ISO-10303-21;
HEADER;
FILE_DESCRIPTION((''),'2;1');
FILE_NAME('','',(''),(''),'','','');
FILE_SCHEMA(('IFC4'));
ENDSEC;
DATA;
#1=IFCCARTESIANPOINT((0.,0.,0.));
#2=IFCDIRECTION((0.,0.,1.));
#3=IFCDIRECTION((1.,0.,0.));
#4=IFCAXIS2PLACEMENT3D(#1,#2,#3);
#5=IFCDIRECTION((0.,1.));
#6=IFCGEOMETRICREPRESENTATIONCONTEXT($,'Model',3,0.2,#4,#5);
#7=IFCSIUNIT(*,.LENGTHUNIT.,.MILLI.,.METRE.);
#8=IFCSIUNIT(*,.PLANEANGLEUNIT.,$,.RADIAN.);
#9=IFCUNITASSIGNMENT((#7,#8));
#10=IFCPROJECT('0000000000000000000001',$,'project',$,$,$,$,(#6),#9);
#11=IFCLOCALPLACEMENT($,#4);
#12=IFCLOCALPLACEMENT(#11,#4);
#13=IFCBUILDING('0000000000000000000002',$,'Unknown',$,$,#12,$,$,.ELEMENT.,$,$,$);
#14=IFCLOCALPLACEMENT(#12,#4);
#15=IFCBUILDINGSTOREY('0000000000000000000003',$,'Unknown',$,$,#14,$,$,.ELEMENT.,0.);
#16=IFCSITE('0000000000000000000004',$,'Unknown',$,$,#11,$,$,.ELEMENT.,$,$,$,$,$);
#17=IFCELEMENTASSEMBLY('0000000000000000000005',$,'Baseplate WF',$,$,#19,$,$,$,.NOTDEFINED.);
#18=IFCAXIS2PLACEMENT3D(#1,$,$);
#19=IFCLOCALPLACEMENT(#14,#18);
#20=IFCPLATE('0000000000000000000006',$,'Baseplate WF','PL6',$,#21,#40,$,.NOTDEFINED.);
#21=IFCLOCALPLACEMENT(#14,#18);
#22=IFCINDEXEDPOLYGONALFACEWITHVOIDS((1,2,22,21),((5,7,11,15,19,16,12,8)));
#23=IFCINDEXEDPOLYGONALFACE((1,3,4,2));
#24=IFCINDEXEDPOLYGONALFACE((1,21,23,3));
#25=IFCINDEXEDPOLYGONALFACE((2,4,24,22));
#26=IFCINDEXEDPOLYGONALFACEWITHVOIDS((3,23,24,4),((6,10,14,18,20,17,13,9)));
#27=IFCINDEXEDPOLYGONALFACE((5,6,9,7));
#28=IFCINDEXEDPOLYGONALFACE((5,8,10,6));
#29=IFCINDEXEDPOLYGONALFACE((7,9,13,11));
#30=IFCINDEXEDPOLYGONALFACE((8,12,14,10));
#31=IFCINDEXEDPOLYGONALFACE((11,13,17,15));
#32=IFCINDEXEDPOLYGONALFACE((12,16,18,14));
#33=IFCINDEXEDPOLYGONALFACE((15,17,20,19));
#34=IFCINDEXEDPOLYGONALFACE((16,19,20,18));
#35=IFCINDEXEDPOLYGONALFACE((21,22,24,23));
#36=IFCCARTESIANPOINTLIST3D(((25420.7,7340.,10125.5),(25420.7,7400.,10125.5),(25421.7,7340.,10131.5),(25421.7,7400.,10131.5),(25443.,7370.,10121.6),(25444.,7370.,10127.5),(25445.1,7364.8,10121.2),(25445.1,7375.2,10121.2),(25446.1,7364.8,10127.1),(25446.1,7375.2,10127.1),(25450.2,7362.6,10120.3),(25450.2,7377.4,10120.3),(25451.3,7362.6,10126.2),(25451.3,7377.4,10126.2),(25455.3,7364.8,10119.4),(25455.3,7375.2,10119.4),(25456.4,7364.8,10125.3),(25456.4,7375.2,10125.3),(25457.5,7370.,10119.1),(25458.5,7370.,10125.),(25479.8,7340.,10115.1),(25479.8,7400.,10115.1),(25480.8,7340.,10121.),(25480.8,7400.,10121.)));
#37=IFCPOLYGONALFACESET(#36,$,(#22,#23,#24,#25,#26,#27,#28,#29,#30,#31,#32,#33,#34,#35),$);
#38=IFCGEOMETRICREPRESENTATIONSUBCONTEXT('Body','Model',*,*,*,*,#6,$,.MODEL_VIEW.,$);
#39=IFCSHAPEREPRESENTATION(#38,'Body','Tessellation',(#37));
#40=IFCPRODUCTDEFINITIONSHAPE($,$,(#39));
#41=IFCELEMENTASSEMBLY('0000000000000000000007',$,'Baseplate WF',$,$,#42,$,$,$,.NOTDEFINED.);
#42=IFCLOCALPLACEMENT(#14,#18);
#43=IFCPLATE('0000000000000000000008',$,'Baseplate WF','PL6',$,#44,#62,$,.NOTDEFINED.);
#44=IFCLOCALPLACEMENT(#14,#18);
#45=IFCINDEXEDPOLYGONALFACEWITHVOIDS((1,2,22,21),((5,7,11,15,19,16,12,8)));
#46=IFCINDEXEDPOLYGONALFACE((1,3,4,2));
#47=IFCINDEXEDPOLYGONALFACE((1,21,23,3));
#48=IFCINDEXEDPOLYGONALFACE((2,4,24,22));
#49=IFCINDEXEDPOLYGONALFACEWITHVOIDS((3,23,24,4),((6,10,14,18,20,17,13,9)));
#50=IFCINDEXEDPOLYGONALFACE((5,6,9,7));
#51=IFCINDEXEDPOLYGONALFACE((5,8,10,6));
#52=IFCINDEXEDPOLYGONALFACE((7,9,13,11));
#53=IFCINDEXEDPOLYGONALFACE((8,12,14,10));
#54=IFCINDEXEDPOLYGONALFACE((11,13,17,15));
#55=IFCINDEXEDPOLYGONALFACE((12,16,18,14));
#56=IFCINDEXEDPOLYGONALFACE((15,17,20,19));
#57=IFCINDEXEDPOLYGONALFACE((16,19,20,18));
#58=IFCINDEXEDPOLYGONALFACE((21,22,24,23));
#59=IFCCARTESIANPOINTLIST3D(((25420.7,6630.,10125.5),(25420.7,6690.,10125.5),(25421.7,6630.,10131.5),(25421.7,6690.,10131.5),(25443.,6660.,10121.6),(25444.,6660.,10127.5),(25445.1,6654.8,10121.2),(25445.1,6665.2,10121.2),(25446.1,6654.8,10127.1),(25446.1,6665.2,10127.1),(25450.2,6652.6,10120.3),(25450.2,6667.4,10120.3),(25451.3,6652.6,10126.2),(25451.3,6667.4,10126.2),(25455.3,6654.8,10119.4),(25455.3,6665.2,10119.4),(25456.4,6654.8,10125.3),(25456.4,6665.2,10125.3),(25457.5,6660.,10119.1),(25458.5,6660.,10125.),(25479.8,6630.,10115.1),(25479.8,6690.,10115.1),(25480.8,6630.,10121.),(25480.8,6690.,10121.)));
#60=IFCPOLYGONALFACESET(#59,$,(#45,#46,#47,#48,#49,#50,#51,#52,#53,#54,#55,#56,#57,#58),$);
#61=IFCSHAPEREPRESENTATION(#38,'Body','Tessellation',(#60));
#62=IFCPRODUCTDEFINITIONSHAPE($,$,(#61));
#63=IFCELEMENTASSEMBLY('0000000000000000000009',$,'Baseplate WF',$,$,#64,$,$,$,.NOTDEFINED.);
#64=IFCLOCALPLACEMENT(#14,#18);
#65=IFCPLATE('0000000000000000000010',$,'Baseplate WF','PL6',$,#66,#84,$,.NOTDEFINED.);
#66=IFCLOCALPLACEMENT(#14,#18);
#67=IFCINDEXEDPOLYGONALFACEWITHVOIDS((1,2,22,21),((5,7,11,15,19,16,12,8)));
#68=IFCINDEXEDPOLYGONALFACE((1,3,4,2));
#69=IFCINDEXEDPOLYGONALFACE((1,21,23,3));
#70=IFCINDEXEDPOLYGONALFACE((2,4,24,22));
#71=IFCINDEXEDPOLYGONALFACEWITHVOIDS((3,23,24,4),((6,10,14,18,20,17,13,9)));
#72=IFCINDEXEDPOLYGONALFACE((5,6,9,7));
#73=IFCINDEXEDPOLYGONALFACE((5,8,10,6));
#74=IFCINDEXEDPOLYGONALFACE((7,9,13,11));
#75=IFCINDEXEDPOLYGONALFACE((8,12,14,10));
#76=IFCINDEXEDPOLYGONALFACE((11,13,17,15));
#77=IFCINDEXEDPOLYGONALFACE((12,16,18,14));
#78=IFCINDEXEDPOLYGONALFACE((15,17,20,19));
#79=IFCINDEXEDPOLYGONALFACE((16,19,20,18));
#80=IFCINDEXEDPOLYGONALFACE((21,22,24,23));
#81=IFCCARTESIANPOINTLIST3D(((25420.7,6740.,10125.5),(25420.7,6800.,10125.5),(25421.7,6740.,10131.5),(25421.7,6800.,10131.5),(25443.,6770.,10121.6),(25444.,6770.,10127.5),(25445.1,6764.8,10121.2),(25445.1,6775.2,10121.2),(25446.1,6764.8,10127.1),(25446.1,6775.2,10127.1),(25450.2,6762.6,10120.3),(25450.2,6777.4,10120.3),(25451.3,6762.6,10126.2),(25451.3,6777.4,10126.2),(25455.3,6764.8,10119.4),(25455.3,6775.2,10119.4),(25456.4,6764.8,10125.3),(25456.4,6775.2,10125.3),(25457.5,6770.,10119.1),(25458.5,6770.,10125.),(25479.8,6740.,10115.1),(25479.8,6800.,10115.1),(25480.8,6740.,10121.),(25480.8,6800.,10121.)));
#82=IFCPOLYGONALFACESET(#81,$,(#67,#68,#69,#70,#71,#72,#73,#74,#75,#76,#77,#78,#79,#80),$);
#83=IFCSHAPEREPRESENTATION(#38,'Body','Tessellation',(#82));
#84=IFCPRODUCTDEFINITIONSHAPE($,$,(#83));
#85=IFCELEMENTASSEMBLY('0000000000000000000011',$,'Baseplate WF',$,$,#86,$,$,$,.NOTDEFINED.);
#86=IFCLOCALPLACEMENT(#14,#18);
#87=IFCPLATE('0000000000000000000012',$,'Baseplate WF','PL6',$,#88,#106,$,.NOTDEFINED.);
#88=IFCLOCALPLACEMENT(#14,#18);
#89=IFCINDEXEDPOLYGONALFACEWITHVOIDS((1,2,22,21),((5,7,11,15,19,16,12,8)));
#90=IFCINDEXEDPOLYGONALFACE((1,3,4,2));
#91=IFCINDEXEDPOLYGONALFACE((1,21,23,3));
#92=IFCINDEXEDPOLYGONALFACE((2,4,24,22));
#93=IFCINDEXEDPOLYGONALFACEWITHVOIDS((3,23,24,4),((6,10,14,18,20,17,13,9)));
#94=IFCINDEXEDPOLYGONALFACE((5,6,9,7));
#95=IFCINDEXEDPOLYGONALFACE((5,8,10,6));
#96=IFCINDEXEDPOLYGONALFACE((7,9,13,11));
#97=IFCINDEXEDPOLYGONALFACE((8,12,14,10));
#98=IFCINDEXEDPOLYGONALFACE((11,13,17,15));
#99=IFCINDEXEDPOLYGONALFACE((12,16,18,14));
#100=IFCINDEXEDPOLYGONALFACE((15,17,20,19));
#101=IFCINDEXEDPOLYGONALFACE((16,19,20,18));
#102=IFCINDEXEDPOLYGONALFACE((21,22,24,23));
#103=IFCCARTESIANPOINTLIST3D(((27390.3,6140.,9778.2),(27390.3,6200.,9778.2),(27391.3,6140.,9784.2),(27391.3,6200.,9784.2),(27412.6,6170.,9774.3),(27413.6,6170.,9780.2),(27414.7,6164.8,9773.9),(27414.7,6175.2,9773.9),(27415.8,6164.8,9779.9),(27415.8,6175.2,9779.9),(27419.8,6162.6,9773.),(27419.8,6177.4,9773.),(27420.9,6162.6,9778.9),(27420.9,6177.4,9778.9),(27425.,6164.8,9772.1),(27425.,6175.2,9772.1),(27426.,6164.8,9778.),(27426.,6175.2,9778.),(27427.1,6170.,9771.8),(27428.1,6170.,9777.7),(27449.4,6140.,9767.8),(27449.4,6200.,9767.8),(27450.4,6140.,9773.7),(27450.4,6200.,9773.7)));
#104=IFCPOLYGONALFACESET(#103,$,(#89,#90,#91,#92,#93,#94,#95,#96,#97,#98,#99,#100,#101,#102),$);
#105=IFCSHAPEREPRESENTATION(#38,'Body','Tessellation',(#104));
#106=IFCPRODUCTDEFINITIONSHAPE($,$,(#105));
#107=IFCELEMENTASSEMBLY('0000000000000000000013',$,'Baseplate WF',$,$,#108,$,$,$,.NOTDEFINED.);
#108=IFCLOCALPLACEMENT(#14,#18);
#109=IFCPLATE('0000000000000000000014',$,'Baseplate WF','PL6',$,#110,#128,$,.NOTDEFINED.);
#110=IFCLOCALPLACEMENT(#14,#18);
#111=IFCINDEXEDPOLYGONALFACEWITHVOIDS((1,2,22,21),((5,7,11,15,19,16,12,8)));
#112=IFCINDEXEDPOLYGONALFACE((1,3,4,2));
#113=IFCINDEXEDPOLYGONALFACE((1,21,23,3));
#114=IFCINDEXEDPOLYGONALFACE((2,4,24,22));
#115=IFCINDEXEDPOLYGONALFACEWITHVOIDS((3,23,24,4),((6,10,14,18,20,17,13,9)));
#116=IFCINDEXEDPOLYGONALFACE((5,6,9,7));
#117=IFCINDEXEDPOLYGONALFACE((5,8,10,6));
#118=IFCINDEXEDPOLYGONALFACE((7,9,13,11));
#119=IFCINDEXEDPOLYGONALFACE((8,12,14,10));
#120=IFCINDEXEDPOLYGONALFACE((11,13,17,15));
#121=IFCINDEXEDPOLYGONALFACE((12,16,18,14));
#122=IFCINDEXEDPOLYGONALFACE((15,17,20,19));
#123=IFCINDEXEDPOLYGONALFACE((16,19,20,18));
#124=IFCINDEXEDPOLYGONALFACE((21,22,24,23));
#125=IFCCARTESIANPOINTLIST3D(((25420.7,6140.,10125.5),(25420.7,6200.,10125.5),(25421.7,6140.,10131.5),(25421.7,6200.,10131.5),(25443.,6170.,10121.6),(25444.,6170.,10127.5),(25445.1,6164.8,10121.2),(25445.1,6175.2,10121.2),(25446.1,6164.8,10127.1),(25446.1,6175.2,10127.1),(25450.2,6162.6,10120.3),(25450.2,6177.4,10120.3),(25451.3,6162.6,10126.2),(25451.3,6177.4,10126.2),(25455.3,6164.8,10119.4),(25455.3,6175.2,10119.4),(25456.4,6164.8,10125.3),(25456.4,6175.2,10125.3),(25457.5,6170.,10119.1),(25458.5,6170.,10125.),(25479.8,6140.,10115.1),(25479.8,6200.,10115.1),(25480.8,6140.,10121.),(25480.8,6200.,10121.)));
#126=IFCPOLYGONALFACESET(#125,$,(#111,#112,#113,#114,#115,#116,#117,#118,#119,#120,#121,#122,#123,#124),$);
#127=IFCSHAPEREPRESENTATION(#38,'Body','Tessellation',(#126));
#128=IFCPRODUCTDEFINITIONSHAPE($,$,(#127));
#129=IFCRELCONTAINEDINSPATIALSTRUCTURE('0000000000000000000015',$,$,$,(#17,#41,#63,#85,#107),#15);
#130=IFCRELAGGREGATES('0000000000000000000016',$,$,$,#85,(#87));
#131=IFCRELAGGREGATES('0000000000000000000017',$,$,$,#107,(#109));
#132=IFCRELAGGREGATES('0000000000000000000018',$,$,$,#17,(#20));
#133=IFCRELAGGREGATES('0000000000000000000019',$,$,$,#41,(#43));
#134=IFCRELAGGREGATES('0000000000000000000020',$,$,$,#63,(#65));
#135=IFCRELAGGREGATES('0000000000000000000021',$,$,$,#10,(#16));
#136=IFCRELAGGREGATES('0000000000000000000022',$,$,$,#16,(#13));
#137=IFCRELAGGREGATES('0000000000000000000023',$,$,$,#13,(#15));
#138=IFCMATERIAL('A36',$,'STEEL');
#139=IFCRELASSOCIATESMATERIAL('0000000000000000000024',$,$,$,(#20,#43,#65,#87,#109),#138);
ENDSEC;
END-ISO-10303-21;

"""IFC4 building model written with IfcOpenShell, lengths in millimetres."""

from ifc_helpers import new_model, si_unit, direction, frame, origin_with_axes, place, context, subcontext, project, spatial, line, indexed_curve, outline, extrude, material, element, aggregate, save


model = new_model("IFC4")

# Units and contexts
model_context = context("Model", 3, precision=0.2, world=origin_with_axes(), true_north=direction((0.0, 1.0)))
body_context = subcontext(model_context, "Body", "Model", "MODEL_VIEW")
ifc_project = project(units=[si_unit("LENGTHUNIT", "METRE", prefix="MILLI"), si_unit("PLANEANGLEUNIT", "RADIAN")], contexts=[model_context])

# Site, building, storey
site_placement = place(None, origin_with_axes())
site = spatial("IfcSite", under=ifc_project, at=site_placement, Name="Unknown", CompositionType="ELEMENT")
building_placement = place(site_placement, origin_with_axes())
building = spatial("IfcBuilding", under=site, at=building_placement, Name="Unknown", CompositionType="ELEMENT")
storey_placement = place(building_placement, origin_with_axes())
storey = spatial("IfcBuildingStorey", under=building, at=storey_placement, Name="Unknown", CompositionType="ELEMENT", Elevation=0.0)

# Shared definitions
ifc_material_1 = material(Name="A36", Category="STEEL")

# Element assemblies, plates, voiding features
assembly_1_placement = place(storey_placement, frame((25480.3, 7400.0, 10118.1), z_axis=(-0.173648, 0.0, -0.984808), x_axis=(0.0, -1.0, 0.0)))
assembly_1 = element("IfcElementAssembly", 1, at=assembly_1_placement, inside=storey, Name="Baseplate WF", PredefinedType="NOTDEFINED")
plate_1_placement = place(assembly_1_placement, origin_with_axes())
plate_1 = element("IfcPlate", 2, at=plate_1_placement, material=ifc_material_1, Name="Baseplate WF", Description="PL6", PredefinedType="NOTDEFINED", context=body_context, shape_type="SolidModel", body=[
    extrude(outline(indexed_curve([(0.0, 0.0), (60.0, 0.0), (60.0, 60.0), (0.0, 60.0)], segments=[line(1, 2, 3, 4, 1)])), frame((0.0, 0.0, 3.0), z_axis=(0.0, 0.0, 1.0), x_axis=(1.0, 0.0, 0.0)), (0.0, 0.0, -1.0), 6.0),
])
voiding_feature_1_placement = place(plate_1_placement, frame((140.0, 30.0, -3.5), z_axis=(-1.0, 0.0, 0.0), x_axis=(0.0, 0.0, 1.0)))
element("IfcVoidingFeature", 3, at=voiding_feature_1_placement, cuts=plate_1, Name="BEAM", PredefinedType="HOLE", context=body_context, shape_type="SolidModel", body=[
    extrude(outline(indexed_curve([(7.4, 0.0), (5.2, 5.2), (0.0, 7.4), (-5.2, 5.2), (-7.4, 0.0), (-5.2, -5.2), (0.0, -7.4), (5.2, -5.2)], segments=[line(1, 2, 3, 4, 5, 6, 7, 8, 1)])), frame((0.0, 0.0, 0.0), z_axis=(-1.0, 0.0, 0.0), x_axis=(0.0, 0.0, 1.0)), (0.0, 0.0, -1.0), 7.0),
])
voiding_feature_2_placement = place(plate_1_placement, frame((30.0, 30.0, -3.5), z_axis=(-1.0, 0.0, 0.0), x_axis=(0.0, 0.0, 1.0)))
element("IfcVoidingFeature", 4, at=voiding_feature_2_placement, cuts=plate_1, Name="BEAM", PredefinedType="HOLE", context=body_context, shape_type="SolidModel", body=[
    extrude(outline(indexed_curve([(7.4, 0.0), (5.2, 5.2), (0.0, 7.4), (-5.2, 5.2), (-7.4, 0.0), (-5.2, -5.2), (0.0, -7.4), (5.2, -5.2)], segments=[line(1, 2, 3, 4, 5, 6, 7, 8, 1)])), frame((0.0, 0.0, 0.0), z_axis=(-1.0, 0.0, 0.0), x_axis=(0.0, 0.0, 1.0)), (0.0, 0.0, -1.0), 7.0),
])
assembly_2_placement = place(storey_placement, frame((25480.3, 6690.0, 10118.1), z_axis=(-0.173648, 0.0, -0.984808), x_axis=(0.0, -1.0, 0.0)))
assembly_2 = element("IfcElementAssembly", 5, at=assembly_2_placement, inside=storey, Name="Baseplate WF", PredefinedType="NOTDEFINED")
plate_2_placement = place(assembly_2_placement, origin_with_axes())
plate_2 = element("IfcPlate", 6, at=plate_2_placement, material=ifc_material_1, Name="Baseplate WF", Description="PL6", PredefinedType="NOTDEFINED", context=body_context, shape_type="SolidModel", body=[
    extrude(outline(indexed_curve([(0.0, 0.0), (60.0, 0.0), (60.0, 60.0), (0.0, 60.0)], segments=[line(1, 2, 3, 4, 1)])), frame((0.0, 0.0, 3.0), z_axis=(0.0, 0.0, 1.0), x_axis=(1.0, 0.0, 0.0)), (0.0, 0.0, -1.0), 6.0),
])
voiding_feature_3_placement = place(plate_2_placement, frame((30.0, 30.0, -3.5), z_axis=(-1.0, 0.0, 0.0), x_axis=(0.0, 0.0, 1.0)))
element("IfcVoidingFeature", 7, at=voiding_feature_3_placement, cuts=plate_2, Name="BEAM", PredefinedType="HOLE", context=body_context, shape_type="SolidModel", body=[
    extrude(outline(indexed_curve([(7.4, 0.0), (5.2, 5.2), (0.0, 7.4), (-5.2, 5.2), (-7.4, 0.0), (-5.2, -5.2), (0.0, -7.4), (5.2, -5.2)], segments=[line(1, 2, 3, 4, 5, 6, 7, 8, 1)])), frame((0.0, 0.0, 0.0), z_axis=(-1.0, 0.0, 0.0), x_axis=(0.0, 0.0, 1.0)), (0.0, 0.0, -1.0), 7.0),
])
voiding_feature_4_placement = place(plate_2_placement, frame((-80.0, 30.0, -3.5), z_axis=(-1.0, 0.0, 0.0), x_axis=(0.0, 0.0, 1.0)))
element("IfcVoidingFeature", 8, at=voiding_feature_4_placement, cuts=plate_2, Name="BEAM", PredefinedType="HOLE", context=body_context, shape_type="SolidModel", body=[
    extrude(outline(indexed_curve([(7.4, 0.0), (5.2, 5.2), (0.0, 7.4), (-5.2, 5.2), (-7.4, 0.0), (-5.2, -5.2), (0.0, -7.4), (5.2, -5.2)], segments=[line(1, 2, 3, 4, 5, 6, 7, 8, 1)])), frame((0.0, 0.0, 0.0), z_axis=(-1.0, 0.0, 0.0), x_axis=(0.0, 0.0, 1.0)), (0.0, 0.0, -1.0), 7.0),
])
assembly_3_placement = place(storey_placement, frame((25480.3, 6800.0, 10118.1), z_axis=(-0.173648, 0.0, -0.984808), x_axis=(0.0, -1.0, 0.0)))
assembly_3 = element("IfcElementAssembly", 9, at=assembly_3_placement, inside=storey, Name="Baseplate WF", PredefinedType="NOTDEFINED")
plate_3_placement = place(assembly_3_placement, origin_with_axes())
plate_3 = element("IfcPlate", 10, at=plate_3_placement, material=ifc_material_1, Name="Baseplate WF", Description="PL6", PredefinedType="NOTDEFINED", context=body_context, shape_type="SolidModel", body=[
    extrude(outline(indexed_curve([(0.0, 0.0), (60.0, 0.0), (60.0, 60.0), (0.0, 60.0)], segments=[line(1, 2, 3, 4, 1)])), frame((0.0, 0.0, 3.0), z_axis=(0.0, 0.0, 1.0), x_axis=(1.0, 0.0, 0.0)), (0.0, 0.0, -1.0), 6.0),
])
voiding_feature_5_placement = place(plate_3_placement, frame((140.0, 30.0, -3.5), z_axis=(-1.0, 0.0, 0.0), x_axis=(0.0, 0.0, 1.0)))
element("IfcVoidingFeature", 11, at=voiding_feature_5_placement, cuts=plate_3, Name="BEAM", PredefinedType="HOLE", context=body_context, shape_type="SolidModel", body=[
    extrude(outline(indexed_curve([(7.4, 0.0), (5.2, 5.2), (0.0, 7.4), (-5.2, 5.2), (-7.4, 0.0), (-5.2, -5.2), (0.0, -7.4), (5.2, -5.2)], segments=[line(1, 2, 3, 4, 5, 6, 7, 8, 1)])), frame((0.0, 0.0, 0.0), z_axis=(-1.0, 0.0, 0.0), x_axis=(0.0, 0.0, 1.0)), (0.0, 0.0, -1.0), 7.0),
])
voiding_feature_6_placement = place(plate_3_placement, frame((30.0, 30.0, -3.5), z_axis=(-1.0, 0.0, 0.0), x_axis=(0.0, 0.0, 1.0)))
element("IfcVoidingFeature", 12, at=voiding_feature_6_placement, cuts=plate_3, Name="BEAM", PredefinedType="HOLE", context=body_context, shape_type="SolidModel", body=[
    extrude(outline(indexed_curve([(7.4, 0.0), (5.2, 5.2), (0.0, 7.4), (-5.2, 5.2), (-7.4, 0.0), (-5.2, -5.2), (0.0, -7.4), (5.2, -5.2)], segments=[line(1, 2, 3, 4, 5, 6, 7, 8, 1)])), frame((0.0, 0.0, 0.0), z_axis=(-1.0, 0.0, 0.0), x_axis=(0.0, 0.0, 1.0)), (0.0, 0.0, -1.0), 7.0),
])
assembly_4_placement = place(storey_placement, frame((27449.9, 6200.0, 9770.8), z_axis=(-0.173648, 0.0, -0.984808), x_axis=(0.0, -1.0, 0.0)))
assembly_4 = element("IfcElementAssembly", 13, at=assembly_4_placement, inside=storey, Name="Baseplate WF", PredefinedType="NOTDEFINED")
plate_4_placement = place(assembly_4_placement, origin_with_axes())
plate_4 = element("IfcPlate", 14, at=plate_4_placement, material=ifc_material_1, Name="Baseplate WF", Description="PL6", PredefinedType="NOTDEFINED", context=body_context, shape_type="SolidModel", body=[
    extrude(outline(indexed_curve([(0.0, 0.0), (60.0, 0.0), (60.0, 60.0), (0.0, 60.0)], segments=[line(1, 2, 3, 4, 1)])), frame((0.0, 0.0, 3.0), z_axis=(0.0, 0.0, 1.0), x_axis=(1.0, 0.0, 0.0)), (0.0, 0.0, -1.0), 6.0),
])
voiding_feature_7_placement = place(plate_4_placement, frame((140.0, 30.0, -3.5), z_axis=(-1.0, 0.0, 0.0), x_axis=(0.0, 0.0, 1.0)))
element("IfcVoidingFeature", 15, at=voiding_feature_7_placement, cuts=plate_4, Name="BEAM", PredefinedType="HOLE", context=body_context, shape_type="SolidModel", body=[
    extrude(outline(indexed_curve([(7.4, 0.0), (5.2, 5.2), (0.0, 7.4), (-5.2, 5.2), (-7.4, 0.0), (-5.2, -5.2), (0.0, -7.4), (5.2, -5.2)], segments=[line(1, 2, 3, 4, 5, 6, 7, 8, 1)])), frame((0.0, 0.0, 0.0), z_axis=(-1.0, 0.0, 0.0), x_axis=(0.0, 0.0, 1.0)), (0.0, 0.0, -1.0), 7.0),
])
voiding_feature_8_placement = place(plate_4_placement, frame((30.0, 30.0, -3.5), z_axis=(-1.0, 0.0, 0.0), x_axis=(0.0, 0.0, 1.0)))
element("IfcVoidingFeature", 16, at=voiding_feature_8_placement, cuts=plate_4, Name="BEAM", PredefinedType="HOLE", context=body_context, shape_type="SolidModel", body=[
    extrude(outline(indexed_curve([(7.4, 0.0), (5.2, 5.2), (0.0, 7.4), (-5.2, 5.2), (-7.4, 0.0), (-5.2, -5.2), (0.0, -7.4), (5.2, -5.2)], segments=[line(1, 2, 3, 4, 5, 6, 7, 8, 1)])), frame((0.0, 0.0, 0.0), z_axis=(-1.0, 0.0, 0.0), x_axis=(0.0, 0.0, 1.0)), (0.0, 0.0, -1.0), 7.0),
])
aggregate(assembly_4, [plate_4])
assembly_5_placement = place(storey_placement, frame((25480.3, 6200.0, 10118.1), z_axis=(-0.173648, 0.0, -0.984808), x_axis=(0.0, -1.0, 0.0)))
assembly_5 = element("IfcElementAssembly", 17, at=assembly_5_placement, inside=storey, Name="Baseplate WF", PredefinedType="NOTDEFINED")
plate_5_placement = place(assembly_5_placement, origin_with_axes())
plate_5 = element("IfcPlate", 18, at=plate_5_placement, material=ifc_material_1, Name="Baseplate WF", Description="PL6", PredefinedType="NOTDEFINED", context=body_context, shape_type="SolidModel", body=[
    extrude(outline(indexed_curve([(0.0, 0.0), (60.0, 0.0), (60.0, 60.0), (0.0, 60.0)], segments=[line(1, 2, 3, 4, 1)])), frame((0.0, 0.0, 3.0), z_axis=(0.0, 0.0, 1.0), x_axis=(1.0, 0.0, 0.0)), (0.0, 0.0, -1.0), 6.0),
])
voiding_feature_9_placement = place(plate_5_placement, frame((140.0, 30.0, -3.5), z_axis=(-1.0, 0.0, 0.0), x_axis=(0.0, 0.0, 1.0)))
element("IfcVoidingFeature", 19, at=voiding_feature_9_placement, cuts=plate_5, Name="BEAM", PredefinedType="HOLE", context=body_context, shape_type="SolidModel", body=[
    extrude(outline(indexed_curve([(7.4, 0.0), (5.2, 5.2), (0.0, 7.4), (-5.2, 5.2), (-7.4, 0.0), (-5.2, -5.2), (0.0, -7.4), (5.2, -5.2)], segments=[line(1, 2, 3, 4, 5, 6, 7, 8, 1)])), frame((0.0, 0.0, 0.0), z_axis=(-1.0, 0.0, 0.0), x_axis=(0.0, 0.0, 1.0)), (0.0, 0.0, -1.0), 7.0),
])
voiding_feature_10_placement = place(plate_5_placement, frame((30.0, 30.0, -3.5), z_axis=(-1.0, 0.0, 0.0), x_axis=(0.0, 0.0, 1.0)))
element("IfcVoidingFeature", 20, at=voiding_feature_10_placement, cuts=plate_5, Name="BEAM", PredefinedType="HOLE", context=body_context, shape_type="SolidModel", body=[
    extrude(outline(indexed_curve([(7.4, 0.0), (5.2, 5.2), (0.0, 7.4), (-5.2, 5.2), (-7.4, 0.0), (-5.2, -5.2), (0.0, -7.4), (5.2, -5.2)], segments=[line(1, 2, 3, 4, 5, 6, 7, 8, 1)])), frame((0.0, 0.0, 0.0), z_axis=(-1.0, 0.0, 0.0), x_axis=(0.0, 0.0, 1.0)), (0.0, 0.0, -1.0), 7.0),
])
aggregate(assembly_5, [plate_5])

aggregate(assembly_1, [plate_1])
aggregate(assembly_2, [plate_2])
aggregate(assembly_3, [plate_3])

save(model, "model.ifc")
